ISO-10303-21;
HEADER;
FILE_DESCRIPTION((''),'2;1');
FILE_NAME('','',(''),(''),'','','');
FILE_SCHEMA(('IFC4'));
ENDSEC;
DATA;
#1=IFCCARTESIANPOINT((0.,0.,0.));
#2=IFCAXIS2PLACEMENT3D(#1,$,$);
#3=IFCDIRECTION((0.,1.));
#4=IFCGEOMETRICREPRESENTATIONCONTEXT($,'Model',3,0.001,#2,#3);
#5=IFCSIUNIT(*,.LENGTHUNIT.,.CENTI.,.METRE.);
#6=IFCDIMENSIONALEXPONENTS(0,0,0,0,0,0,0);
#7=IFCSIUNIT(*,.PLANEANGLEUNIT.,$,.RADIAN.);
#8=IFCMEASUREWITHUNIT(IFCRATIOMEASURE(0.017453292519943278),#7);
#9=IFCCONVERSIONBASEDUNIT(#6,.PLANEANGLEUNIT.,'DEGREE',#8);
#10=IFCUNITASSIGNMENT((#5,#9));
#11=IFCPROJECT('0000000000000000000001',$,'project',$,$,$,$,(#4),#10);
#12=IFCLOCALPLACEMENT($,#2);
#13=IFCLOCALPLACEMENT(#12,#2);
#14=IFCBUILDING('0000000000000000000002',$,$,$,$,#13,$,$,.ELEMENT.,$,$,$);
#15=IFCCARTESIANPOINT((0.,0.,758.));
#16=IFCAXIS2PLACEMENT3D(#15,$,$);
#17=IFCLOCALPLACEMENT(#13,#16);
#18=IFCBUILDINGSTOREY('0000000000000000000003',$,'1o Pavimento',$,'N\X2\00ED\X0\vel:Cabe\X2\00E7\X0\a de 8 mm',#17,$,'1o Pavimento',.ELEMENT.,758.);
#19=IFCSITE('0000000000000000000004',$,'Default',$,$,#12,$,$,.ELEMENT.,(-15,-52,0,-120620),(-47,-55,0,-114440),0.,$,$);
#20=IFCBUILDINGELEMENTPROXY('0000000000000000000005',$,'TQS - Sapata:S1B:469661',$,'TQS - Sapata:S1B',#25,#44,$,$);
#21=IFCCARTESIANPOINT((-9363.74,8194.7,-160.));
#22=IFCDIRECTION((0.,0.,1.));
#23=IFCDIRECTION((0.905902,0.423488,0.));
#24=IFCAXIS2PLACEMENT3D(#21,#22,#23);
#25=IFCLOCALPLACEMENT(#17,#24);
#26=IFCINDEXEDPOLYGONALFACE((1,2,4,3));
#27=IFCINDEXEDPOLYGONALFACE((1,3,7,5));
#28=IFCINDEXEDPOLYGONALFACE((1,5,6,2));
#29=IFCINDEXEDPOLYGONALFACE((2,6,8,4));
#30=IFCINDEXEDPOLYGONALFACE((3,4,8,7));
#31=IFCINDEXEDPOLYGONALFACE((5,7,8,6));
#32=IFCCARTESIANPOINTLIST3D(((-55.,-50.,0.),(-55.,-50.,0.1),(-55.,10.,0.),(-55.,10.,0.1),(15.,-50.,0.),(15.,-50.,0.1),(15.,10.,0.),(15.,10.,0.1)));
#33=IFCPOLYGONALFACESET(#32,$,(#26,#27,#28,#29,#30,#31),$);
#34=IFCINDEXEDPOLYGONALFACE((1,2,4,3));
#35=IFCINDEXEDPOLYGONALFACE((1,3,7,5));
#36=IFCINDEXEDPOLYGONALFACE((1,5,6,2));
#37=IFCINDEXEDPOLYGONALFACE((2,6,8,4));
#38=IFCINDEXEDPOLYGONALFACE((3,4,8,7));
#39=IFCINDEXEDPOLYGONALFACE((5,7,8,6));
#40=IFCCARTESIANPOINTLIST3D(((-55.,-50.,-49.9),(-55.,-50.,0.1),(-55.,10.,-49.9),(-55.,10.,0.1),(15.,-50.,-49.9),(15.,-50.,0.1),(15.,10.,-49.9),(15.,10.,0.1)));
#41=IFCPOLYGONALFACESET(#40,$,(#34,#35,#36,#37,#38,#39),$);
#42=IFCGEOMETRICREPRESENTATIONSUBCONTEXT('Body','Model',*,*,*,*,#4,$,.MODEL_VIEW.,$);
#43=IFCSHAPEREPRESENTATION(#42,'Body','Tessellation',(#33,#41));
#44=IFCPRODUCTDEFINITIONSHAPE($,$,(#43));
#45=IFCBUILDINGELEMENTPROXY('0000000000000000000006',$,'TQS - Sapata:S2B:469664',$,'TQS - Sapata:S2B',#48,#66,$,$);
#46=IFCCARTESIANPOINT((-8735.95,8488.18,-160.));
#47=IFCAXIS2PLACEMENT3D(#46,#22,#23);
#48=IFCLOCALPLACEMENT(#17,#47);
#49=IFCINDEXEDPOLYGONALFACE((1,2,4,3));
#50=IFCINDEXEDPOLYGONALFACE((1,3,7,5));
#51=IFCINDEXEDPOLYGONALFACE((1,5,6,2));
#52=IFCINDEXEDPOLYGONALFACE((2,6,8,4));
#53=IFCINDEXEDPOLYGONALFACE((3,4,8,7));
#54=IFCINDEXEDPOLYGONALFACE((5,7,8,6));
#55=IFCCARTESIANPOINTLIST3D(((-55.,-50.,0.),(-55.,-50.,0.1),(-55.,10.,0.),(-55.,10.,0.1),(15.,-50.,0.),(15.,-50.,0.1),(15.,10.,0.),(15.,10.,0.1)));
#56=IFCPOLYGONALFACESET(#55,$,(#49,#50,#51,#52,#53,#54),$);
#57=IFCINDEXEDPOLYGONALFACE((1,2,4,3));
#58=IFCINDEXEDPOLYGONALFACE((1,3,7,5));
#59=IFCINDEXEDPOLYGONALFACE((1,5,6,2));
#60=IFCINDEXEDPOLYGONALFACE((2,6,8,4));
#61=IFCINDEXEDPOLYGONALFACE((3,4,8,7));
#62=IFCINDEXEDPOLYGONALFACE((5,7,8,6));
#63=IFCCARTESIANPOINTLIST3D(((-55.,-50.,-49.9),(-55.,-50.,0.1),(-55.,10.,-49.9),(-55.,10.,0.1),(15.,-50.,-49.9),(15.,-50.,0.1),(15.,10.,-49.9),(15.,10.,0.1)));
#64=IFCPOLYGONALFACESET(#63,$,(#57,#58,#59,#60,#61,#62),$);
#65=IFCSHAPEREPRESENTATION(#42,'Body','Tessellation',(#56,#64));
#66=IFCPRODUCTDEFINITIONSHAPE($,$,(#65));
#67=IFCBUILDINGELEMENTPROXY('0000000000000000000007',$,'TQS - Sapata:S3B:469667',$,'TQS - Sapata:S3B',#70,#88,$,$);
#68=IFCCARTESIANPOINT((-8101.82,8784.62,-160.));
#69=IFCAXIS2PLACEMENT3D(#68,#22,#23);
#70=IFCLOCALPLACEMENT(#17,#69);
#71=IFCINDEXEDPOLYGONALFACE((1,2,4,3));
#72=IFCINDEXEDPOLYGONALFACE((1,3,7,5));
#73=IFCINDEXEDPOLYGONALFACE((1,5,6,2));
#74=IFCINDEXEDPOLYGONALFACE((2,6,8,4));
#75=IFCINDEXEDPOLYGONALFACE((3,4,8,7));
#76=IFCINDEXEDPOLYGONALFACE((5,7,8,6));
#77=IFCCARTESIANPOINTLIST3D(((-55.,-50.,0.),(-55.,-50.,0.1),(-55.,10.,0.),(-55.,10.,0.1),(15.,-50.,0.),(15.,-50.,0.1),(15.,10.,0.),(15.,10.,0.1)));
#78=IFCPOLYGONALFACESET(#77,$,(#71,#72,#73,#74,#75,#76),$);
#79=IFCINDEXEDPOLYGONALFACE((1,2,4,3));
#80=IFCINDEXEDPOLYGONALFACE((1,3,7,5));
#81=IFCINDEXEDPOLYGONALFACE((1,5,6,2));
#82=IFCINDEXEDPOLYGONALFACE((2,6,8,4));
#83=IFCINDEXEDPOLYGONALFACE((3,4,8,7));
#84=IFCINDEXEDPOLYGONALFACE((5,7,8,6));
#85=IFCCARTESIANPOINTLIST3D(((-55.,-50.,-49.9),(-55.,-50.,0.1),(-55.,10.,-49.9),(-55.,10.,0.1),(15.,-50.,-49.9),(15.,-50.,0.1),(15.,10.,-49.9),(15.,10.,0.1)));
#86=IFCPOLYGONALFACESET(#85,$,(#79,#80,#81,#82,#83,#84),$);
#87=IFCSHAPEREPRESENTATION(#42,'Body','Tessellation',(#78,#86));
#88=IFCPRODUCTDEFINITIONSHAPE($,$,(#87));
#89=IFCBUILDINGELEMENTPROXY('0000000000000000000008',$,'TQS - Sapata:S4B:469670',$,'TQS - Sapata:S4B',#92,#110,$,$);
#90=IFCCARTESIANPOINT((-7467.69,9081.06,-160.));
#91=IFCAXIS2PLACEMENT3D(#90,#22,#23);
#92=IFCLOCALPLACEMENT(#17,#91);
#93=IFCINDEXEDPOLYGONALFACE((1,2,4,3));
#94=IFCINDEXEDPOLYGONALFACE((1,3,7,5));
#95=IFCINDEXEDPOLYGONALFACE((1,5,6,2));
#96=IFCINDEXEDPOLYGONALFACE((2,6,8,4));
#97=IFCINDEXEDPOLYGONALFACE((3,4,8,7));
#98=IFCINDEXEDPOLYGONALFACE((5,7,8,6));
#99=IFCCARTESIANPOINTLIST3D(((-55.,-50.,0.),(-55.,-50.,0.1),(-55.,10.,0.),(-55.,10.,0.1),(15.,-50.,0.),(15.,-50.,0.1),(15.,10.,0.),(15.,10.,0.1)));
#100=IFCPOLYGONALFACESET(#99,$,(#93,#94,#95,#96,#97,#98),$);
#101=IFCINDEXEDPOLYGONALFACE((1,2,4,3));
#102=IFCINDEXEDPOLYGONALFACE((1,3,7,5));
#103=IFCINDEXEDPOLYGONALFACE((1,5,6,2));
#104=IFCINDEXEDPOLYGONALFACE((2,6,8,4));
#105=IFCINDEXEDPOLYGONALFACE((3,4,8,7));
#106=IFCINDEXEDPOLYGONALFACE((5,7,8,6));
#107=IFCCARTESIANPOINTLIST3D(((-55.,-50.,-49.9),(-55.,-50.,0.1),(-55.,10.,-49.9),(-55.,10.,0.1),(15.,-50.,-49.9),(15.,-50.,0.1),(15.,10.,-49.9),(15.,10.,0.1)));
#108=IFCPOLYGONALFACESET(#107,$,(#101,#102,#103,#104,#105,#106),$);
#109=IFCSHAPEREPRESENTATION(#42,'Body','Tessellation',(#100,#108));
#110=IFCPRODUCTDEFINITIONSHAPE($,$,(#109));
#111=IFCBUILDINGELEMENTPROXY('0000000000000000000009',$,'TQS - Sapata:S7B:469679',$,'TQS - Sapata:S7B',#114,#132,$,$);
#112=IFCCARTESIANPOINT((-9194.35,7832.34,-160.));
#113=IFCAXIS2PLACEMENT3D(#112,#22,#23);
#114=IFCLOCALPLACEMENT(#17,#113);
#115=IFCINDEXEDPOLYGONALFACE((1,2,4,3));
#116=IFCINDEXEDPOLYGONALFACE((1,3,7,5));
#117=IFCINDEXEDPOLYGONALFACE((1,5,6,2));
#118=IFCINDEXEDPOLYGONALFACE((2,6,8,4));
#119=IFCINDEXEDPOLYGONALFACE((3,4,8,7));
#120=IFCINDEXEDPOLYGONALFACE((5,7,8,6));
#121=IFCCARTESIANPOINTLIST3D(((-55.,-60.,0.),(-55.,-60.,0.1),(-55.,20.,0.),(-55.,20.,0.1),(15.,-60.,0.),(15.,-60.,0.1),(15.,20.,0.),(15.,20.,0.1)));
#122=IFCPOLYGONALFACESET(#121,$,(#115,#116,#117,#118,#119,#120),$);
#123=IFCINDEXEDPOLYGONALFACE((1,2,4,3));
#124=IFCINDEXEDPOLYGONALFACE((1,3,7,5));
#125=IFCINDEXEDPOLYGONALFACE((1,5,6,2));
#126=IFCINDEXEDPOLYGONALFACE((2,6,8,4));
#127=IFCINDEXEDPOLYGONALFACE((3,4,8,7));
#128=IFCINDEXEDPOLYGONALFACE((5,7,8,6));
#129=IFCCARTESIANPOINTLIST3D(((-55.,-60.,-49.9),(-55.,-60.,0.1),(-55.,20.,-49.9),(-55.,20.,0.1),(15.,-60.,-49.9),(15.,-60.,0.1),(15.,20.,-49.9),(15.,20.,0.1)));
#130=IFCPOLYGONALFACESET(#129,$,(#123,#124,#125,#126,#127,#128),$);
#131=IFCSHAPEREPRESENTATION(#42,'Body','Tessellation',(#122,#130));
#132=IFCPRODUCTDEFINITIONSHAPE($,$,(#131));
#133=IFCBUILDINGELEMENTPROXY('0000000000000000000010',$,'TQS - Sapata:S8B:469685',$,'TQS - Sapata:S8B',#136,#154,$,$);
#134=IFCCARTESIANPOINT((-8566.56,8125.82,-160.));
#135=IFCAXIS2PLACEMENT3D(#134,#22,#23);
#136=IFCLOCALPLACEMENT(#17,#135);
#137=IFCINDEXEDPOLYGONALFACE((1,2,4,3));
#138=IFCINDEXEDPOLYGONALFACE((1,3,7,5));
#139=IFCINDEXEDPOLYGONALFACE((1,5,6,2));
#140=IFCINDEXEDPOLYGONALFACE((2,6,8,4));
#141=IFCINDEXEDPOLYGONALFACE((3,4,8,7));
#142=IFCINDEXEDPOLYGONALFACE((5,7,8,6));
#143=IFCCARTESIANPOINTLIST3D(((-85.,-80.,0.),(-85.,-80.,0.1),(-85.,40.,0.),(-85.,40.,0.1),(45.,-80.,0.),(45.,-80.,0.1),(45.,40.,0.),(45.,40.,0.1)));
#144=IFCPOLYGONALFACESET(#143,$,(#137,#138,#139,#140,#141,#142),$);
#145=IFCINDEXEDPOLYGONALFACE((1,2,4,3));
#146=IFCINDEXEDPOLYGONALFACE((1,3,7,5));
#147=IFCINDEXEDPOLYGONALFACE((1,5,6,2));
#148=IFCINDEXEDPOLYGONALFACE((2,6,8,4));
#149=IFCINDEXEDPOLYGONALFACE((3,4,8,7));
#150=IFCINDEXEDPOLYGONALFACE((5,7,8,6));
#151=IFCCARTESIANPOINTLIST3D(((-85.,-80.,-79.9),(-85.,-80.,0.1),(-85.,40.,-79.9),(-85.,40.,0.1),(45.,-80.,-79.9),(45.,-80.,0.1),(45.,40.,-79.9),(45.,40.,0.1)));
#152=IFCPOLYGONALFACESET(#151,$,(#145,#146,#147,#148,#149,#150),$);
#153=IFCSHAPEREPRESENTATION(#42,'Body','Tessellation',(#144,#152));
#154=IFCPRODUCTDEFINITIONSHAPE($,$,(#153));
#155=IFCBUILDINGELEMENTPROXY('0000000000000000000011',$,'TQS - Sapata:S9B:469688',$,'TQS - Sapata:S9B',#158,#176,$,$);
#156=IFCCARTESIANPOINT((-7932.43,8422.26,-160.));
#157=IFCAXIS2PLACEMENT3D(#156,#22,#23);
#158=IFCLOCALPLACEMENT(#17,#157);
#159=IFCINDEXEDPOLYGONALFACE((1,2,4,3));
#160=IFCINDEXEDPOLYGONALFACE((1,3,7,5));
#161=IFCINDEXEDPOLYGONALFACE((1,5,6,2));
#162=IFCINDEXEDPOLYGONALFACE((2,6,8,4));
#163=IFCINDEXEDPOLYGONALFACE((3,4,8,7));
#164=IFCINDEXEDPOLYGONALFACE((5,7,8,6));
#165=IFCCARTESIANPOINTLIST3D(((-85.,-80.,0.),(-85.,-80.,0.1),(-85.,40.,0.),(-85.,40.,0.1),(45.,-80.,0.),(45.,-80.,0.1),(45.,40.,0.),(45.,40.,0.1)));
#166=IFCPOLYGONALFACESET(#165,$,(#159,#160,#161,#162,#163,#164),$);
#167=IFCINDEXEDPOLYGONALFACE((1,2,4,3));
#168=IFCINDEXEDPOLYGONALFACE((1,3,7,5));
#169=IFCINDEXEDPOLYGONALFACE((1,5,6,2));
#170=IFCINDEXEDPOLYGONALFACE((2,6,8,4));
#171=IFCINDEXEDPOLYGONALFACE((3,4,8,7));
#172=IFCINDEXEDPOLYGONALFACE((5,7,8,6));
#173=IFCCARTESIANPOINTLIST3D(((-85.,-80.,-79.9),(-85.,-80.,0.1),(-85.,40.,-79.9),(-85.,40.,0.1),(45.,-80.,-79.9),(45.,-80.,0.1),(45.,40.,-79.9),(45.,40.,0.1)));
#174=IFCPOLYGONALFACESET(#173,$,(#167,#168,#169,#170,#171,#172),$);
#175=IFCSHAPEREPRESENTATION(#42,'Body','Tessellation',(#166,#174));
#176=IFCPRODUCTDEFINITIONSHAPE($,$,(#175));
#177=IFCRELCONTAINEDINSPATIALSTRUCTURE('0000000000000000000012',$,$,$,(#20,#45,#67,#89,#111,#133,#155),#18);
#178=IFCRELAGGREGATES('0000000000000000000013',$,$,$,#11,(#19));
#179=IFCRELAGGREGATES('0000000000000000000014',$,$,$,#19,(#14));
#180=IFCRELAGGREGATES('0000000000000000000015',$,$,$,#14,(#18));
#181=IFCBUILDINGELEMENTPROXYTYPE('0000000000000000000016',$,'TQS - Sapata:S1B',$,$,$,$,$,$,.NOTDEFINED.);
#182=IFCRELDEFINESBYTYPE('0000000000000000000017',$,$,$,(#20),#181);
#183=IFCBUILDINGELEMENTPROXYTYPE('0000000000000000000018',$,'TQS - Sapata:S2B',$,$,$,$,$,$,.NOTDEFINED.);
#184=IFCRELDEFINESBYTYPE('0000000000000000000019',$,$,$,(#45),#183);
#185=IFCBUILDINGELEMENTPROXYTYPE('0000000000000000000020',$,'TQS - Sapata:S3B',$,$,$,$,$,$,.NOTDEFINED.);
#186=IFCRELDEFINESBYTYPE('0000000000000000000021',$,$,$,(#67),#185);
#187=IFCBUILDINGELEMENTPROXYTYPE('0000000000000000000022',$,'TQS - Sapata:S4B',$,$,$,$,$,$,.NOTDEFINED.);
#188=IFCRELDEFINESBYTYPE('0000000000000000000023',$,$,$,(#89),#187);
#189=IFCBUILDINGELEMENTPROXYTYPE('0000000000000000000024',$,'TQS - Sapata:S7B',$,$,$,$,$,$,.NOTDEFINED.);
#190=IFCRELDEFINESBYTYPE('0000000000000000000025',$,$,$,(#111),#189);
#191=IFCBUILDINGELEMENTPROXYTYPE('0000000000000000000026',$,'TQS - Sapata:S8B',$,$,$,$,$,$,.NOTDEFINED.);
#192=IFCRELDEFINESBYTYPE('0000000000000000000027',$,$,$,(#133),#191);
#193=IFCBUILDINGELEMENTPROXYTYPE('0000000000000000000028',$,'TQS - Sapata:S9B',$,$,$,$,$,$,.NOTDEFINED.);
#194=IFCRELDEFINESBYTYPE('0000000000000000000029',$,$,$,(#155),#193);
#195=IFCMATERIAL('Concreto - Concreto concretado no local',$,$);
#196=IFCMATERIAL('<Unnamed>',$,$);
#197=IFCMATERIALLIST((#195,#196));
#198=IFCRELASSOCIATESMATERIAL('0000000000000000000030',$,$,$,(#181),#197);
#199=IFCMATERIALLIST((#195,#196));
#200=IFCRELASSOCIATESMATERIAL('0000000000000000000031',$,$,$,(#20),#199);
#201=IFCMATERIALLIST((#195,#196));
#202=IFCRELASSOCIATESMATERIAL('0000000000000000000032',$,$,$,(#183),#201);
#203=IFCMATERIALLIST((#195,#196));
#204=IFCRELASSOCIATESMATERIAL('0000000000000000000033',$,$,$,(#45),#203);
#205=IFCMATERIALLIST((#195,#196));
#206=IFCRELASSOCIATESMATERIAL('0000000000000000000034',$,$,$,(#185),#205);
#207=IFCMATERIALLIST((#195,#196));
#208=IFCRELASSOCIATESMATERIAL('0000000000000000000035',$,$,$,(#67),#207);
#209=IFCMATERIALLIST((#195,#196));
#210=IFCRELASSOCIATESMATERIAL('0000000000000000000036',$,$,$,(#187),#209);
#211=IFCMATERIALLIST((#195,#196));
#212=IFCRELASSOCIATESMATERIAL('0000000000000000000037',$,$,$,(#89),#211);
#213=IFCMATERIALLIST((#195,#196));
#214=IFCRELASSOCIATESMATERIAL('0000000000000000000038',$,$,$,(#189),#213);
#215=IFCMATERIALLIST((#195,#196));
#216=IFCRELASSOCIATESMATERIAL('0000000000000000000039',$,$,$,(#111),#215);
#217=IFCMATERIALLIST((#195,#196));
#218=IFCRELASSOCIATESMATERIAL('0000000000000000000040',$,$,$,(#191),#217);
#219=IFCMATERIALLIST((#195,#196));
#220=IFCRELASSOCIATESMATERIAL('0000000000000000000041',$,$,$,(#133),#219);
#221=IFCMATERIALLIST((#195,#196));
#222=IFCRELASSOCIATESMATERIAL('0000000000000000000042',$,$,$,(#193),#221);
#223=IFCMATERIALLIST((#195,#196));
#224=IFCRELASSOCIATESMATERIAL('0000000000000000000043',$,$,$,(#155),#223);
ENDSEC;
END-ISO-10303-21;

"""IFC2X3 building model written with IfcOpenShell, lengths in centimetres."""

from ifc_helpers import new_model, entity, si_unit, converted_unit, direction, frame, frame_2d, origin, origin_2d_with_axis, place, context, subcontext, project, spatial, rectangle, extrude, source, transform, mapped, material, material_list, type_object, type_shapes, element, save


model = new_model("IFC2X3")

# Units and contexts
model_context = context("Model", 3, precision=0.001, world=origin(), true_north=direction((0.0, 1.0)))
body_context = subcontext(model_context, "Body", "Model", "MODEL_VIEW")
ifc_project = project(units=[si_unit("LENGTHUNIT", "METRE", prefix="CENTI"), converted_unit("PLANEANGLEUNIT", "DEGREE", entity("IfcRatioMeasure", 0.017453292519943278), si_unit("PLANEANGLEUNIT", "RADIAN"), dimensions=[0, 0, 0, 0, 0, 0, 0])], contexts=[model_context])

# Site, building, storey
site_placement = place(None, origin())
site = spatial("IfcSite", under=ifc_project, at=site_placement, Name="Default", CompositionType="ELEMENT", RefLatitude=(-15, -52, 0, -120620), RefLongitude=(-47, -55, 0, -114440), RefElevation=0.0)
building_placement = place(site_placement, origin())
building = spatial("IfcBuilding", under=site, at=building_placement, CompositionType="ELEMENT")
storey_placement = place(building_placement, frame((0.0, 0.0, 758.0)))
storey = spatial("IfcBuildingStorey", under=building, at=storey_placement, Name="1o Pavimento", ObjectType="Nível:Cabeça de 8 mm", LongName="1o Pavimento", CompositionType="ELEMENT", Elevation=758.0)

# Building element proxies
ifc_material_1 = material(Name="Concreto - Concreto concretado no local")
ifc_material_2 = material(Name="<Unnamed>")
ifc_material_list_1 = material_list([ifc_material_1, ifc_material_2])
ifc_material_list_2 = material_list([ifc_material_1, ifc_material_2])
building_element_proxy_type_1 = type_object("IfcBuildingElementProxyType", Name="TQS - Sapata:S1B", PredefinedType="NOTDEFINED", material=ifc_material_list_2)
shared_shape_1 = source(origin(), body_context, "Body", "SweptSolid", [
    extrude(rectangle(XDim=70.0, YDim=60.0, at=frame_2d((0.0, 0.0), x_axis=(1.0, 0.0))), frame((-20.0, -20.0, 0.0), z_axis=(0.0, 0.0, 1.0), x_axis=(-1.0, 0.0, 0.0)), (0.0, 0.0, 1.0), 0.1),
    extrude(rectangle(XDim=70.0, YDim=60.0, at=frame_2d((0.0, 0.0), x_axis=(1.0, 0.0))), frame((-20.0, -20.0, -49.9), z_axis=(0.0, 0.0, 1.0), x_axis=(-1.0, 0.0, 0.0)), (0.0, 0.0, 1.0), 50.0),
])
type_shapes(building_element_proxy_type_1, [shared_shape_1])
proxy_1_placement = place(storey_placement, frame((-9363.74, 8194.7, -160.0), z_axis=(0.0, 0.0, 1.0), x_axis=(0.905902, 0.423488, 0.0)))
element("IfcBuildingElementProxy", 1, at=proxy_1_placement, inside=storey, type_object=building_element_proxy_type_1, material=ifc_material_list_1, Name="TQS - Sapata:S1B:469661", ObjectType="TQS - Sapata:S1B", context=body_context, shape_type="MappedRepresentation", body=[
    mapped(shared_shape_1, transform((0.0, 0.0, 0.0), scale=1.0)),
])
ifc_material_list_3 = material_list([ifc_material_1, ifc_material_2])
ifc_material_list_4 = material_list([ifc_material_1, ifc_material_2])
building_element_proxy_type_2 = type_object("IfcBuildingElementProxyType", Name="TQS - Sapata:S2B", PredefinedType="NOTDEFINED", material=ifc_material_list_4)
shared_shape_2 = source(origin(), body_context, "Body", "SweptSolid", [
    extrude(rectangle(XDim=70.0, YDim=60.0, at=frame_2d((0.0, 0.0), x_axis=(1.0, 0.0))), frame((-20.0, -20.0, 0.0), z_axis=(0.0, 0.0, 1.0), x_axis=(-1.0, 0.0, 0.0)), (0.0, 0.0, 1.0), 0.1),
    extrude(rectangle(XDim=70.0, YDim=60.0, at=frame_2d((0.0, 0.0), x_axis=(1.0, 0.0))), frame((-20.0, -20.0, -49.9), z_axis=(0.0, 0.0, 1.0), x_axis=(-1.0, 0.0, 0.0)), (0.0, 0.0, 1.0), 50.0),
])
type_shapes(building_element_proxy_type_2, [shared_shape_2])
proxy_2_placement = place(storey_placement, frame((-8735.95, 8488.18, -160.0), z_axis=(0.0, 0.0, 1.0), x_axis=(0.905902, 0.423488, 0.0)))
element("IfcBuildingElementProxy", 2, at=proxy_2_placement, inside=storey, type_object=building_element_proxy_type_2, material=ifc_material_list_3, Name="TQS - Sapata:S2B:469664", ObjectType="TQS - Sapata:S2B", context=body_context, shape_type="MappedRepresentation", body=[
    mapped(shared_shape_2, transform((0.0, 0.0, 0.0), scale=1.0)),
])
ifc_material_list_5 = material_list([ifc_material_1, ifc_material_2])
ifc_material_list_6 = material_list([ifc_material_1, ifc_material_2])
building_element_proxy_type_3 = type_object("IfcBuildingElementProxyType", Name="TQS - Sapata:S3B", PredefinedType="NOTDEFINED", material=ifc_material_list_6)
shared_shape_3 = source(origin(), body_context, "Body", "SweptSolid", [
    extrude(rectangle(XDim=70.0, YDim=60.0, at=frame_2d((0.0, 0.0), x_axis=(1.0, 0.0))), frame((-20.0, -20.0, 0.0), z_axis=(0.0, 0.0, 1.0), x_axis=(-1.0, 0.0, 0.0)), (0.0, 0.0, 1.0), 0.1),
    extrude(rectangle(XDim=70.0, YDim=60.0, at=frame_2d((0.0, 0.0), x_axis=(1.0, 0.0))), frame((-20.0, -20.0, -49.9), z_axis=(0.0, 0.0, 1.0), x_axis=(-1.0, 0.0, 0.0)), (0.0, 0.0, 1.0), 50.0),
])
type_shapes(building_element_proxy_type_3, [shared_shape_3])
proxy_3_placement = place(storey_placement, frame((-8101.82, 8784.62, -160.0), z_axis=(0.0, 0.0, 1.0), x_axis=(0.905902, 0.423488, 0.0)))
element("IfcBuildingElementProxy", 3, at=proxy_3_placement, inside=storey, type_object=building_element_proxy_type_3, material=ifc_material_list_5, Name="TQS - Sapata:S3B:469667", ObjectType="TQS - Sapata:S3B", context=body_context, shape_type="MappedRepresentation", body=[
    mapped(shared_shape_3, transform((0.0, 0.0, 0.0), scale=1.0)),
])
ifc_material_list_7 = material_list([ifc_material_1, ifc_material_2])
ifc_material_list_8 = material_list([ifc_material_1, ifc_material_2])
building_element_proxy_type_4 = type_object("IfcBuildingElementProxyType", Name="TQS - Sapata:S4B", PredefinedType="NOTDEFINED", material=ifc_material_list_8)
shared_shape_4 = source(origin(), body_context, "Body", "SweptSolid", [
    extrude(rectangle(XDim=70.0, YDim=60.0, at=frame_2d((0.0, 0.0), x_axis=(1.0, 0.0))), frame((-20.0, -20.0, 0.0), z_axis=(0.0, 0.0, 1.0), x_axis=(-1.0, 0.0, 0.0)), (0.0, 0.0, 1.0), 0.1),
    extrude(rectangle(XDim=70.0, YDim=60.0, at=frame_2d((0.0, 0.0), x_axis=(1.0, 0.0))), frame((-20.0, -20.0, -49.9), z_axis=(0.0, 0.0, 1.0), x_axis=(-1.0, 0.0, 0.0)), (0.0, 0.0, 1.0), 50.0),
])
type_shapes(building_element_proxy_type_4, [shared_shape_4])
proxy_4_placement = place(storey_placement, frame((-7467.69, 9081.06, -160.0), z_axis=(0.0, 0.0, 1.0), x_axis=(0.905902, 0.423488, 0.0)))
element("IfcBuildingElementProxy", 4, at=proxy_4_placement, inside=storey, type_object=building_element_proxy_type_4, material=ifc_material_list_7, Name="TQS - Sapata:S4B:469670", ObjectType="TQS - Sapata:S4B", context=body_context, shape_type="MappedRepresentation", body=[
    mapped(shared_shape_4, transform((0.0, 0.0, 0.0), scale=1.0)),
])
ifc_material_list_9 = material_list([ifc_material_1, ifc_material_2])
ifc_material_list_10 = material_list([ifc_material_1, ifc_material_2])
building_element_proxy_type_5 = type_object("IfcBuildingElementProxyType", Name="TQS - Sapata:S7B", PredefinedType="NOTDEFINED", material=ifc_material_list_10)
shared_shape_5 = source(origin(), body_context, "Body", "SweptSolid", [
    extrude(rectangle(XDim=70.0, YDim=80.0, at=frame_2d((0.0, 0.0), x_axis=(1.0, 0.0))), frame((-20.0, -20.0, 0.0), z_axis=(0.0, 0.0, 1.0), x_axis=(-1.0, 0.0, 0.0)), (0.0, 0.0, 1.0), 0.1),
    extrude(rectangle(XDim=70.0, YDim=80.0, at=frame_2d((0.0, 0.0), x_axis=(1.0, 0.0))), frame((-20.0, -20.0, -49.9), z_axis=(0.0, 0.0, 1.0), x_axis=(-1.0, 0.0, 0.0)), (0.0, 0.0, 1.0), 50.0),
])
type_shapes(building_element_proxy_type_5, [shared_shape_5])
proxy_5_placement = place(storey_placement, frame((-9194.35, 7832.34, -160.0), z_axis=(0.0, 0.0, 1.0), x_axis=(0.905902, 0.423488, 0.0)))
element("IfcBuildingElementProxy", 5, at=proxy_5_placement, inside=storey, type_object=building_element_proxy_type_5, material=ifc_material_list_9, Name="TQS - Sapata:S7B:469679", ObjectType="TQS - Sapata:S7B", context=body_context, shape_type="MappedRepresentation", body=[
    mapped(shared_shape_5, transform((0.0, 0.0, 0.0), scale=1.0)),
])
ifc_material_list_11 = material_list([ifc_material_1, ifc_material_2])
ifc_material_list_12 = material_list([ifc_material_1, ifc_material_2])
building_element_proxy_type_6 = type_object("IfcBuildingElementProxyType", Name="TQS - Sapata:S8B", PredefinedType="NOTDEFINED", material=ifc_material_list_12)
shared_shape_6 = source(origin(), body_context, "Body", "SweptSolid", [
    extrude(rectangle(XDim=130.0, YDim=120.0, at=frame_2d((0.0, 0.0), x_axis=(1.0, 0.0))), frame((-20.0, -20.0, 0.0), z_axis=(0.0, 0.0, 1.0), x_axis=(-1.0, 0.0, 0.0)), (0.0, 0.0, 1.0), 0.1),
    extrude(rectangle(XDim=130.0, YDim=120.0, at=origin_2d_with_axis()), frame((-20.0, -20.0, -79.9), z_axis=(0.0, 0.0, 1.0), x_axis=(-1.0, 0.0, 0.0)), (0.0, 0.0, 1.0), 80.0),
])
type_shapes(building_element_proxy_type_6, [shared_shape_6])
proxy_6_placement = place(storey_placement, frame((-8566.56, 8125.82, -160.0), z_axis=(0.0, 0.0, 1.0), x_axis=(0.905902, 0.423488, 0.0)))
element("IfcBuildingElementProxy", 6, at=proxy_6_placement, inside=storey, type_object=building_element_proxy_type_6, material=ifc_material_list_11, Name="TQS - Sapata:S8B:469685", ObjectType="TQS - Sapata:S8B", context=body_context, shape_type="MappedRepresentation", body=[
    mapped(shared_shape_6, transform((0.0, 0.0, 0.0), scale=1.0)),
])
ifc_material_list_13 = material_list([ifc_material_1, ifc_material_2])
ifc_material_list_14 = material_list([ifc_material_1, ifc_material_2])
building_element_proxy_type_7 = type_object("IfcBuildingElementProxyType", Name="TQS - Sapata:S9B", PredefinedType="NOTDEFINED", material=ifc_material_list_14)
shared_shape_7 = source(origin(), body_context, "Body", "SweptSolid", [
    extrude(rectangle(XDim=130.0, YDim=120.0, at=frame_2d((0.0, 0.0), x_axis=(1.0, 0.0))), frame((-20.0, -20.0, 0.0), z_axis=(0.0, 0.0, 1.0), x_axis=(-1.0, 0.0, 0.0)), (0.0, 0.0, 1.0), 0.1),
    extrude(rectangle(XDim=130.0, YDim=120.0, at=origin_2d_with_axis()), frame((-20.0, -20.0, -79.9), z_axis=(0.0, 0.0, 1.0), x_axis=(-1.0, 0.0, 0.0)), (0.0, 0.0, 1.0), 80.0),
])
type_shapes(building_element_proxy_type_7, [shared_shape_7])
proxy_7_placement = place(storey_placement, frame((-7932.43, 8422.26, -160.0), z_axis=(0.0, 0.0, 1.0), x_axis=(0.905902, 0.423488, 0.0)))
element("IfcBuildingElementProxy", 7, at=proxy_7_placement, inside=storey, type_object=building_element_proxy_type_7, material=ifc_material_list_13, Name="TQS - Sapata:S9B:469688", ObjectType="TQS - Sapata:S9B", context=body_context, shape_type="MappedRepresentation", body=[
    mapped(shared_shape_7, transform((0.0, 0.0, 0.0), scale=1.0)),
])

save(model, "model.ifc")
